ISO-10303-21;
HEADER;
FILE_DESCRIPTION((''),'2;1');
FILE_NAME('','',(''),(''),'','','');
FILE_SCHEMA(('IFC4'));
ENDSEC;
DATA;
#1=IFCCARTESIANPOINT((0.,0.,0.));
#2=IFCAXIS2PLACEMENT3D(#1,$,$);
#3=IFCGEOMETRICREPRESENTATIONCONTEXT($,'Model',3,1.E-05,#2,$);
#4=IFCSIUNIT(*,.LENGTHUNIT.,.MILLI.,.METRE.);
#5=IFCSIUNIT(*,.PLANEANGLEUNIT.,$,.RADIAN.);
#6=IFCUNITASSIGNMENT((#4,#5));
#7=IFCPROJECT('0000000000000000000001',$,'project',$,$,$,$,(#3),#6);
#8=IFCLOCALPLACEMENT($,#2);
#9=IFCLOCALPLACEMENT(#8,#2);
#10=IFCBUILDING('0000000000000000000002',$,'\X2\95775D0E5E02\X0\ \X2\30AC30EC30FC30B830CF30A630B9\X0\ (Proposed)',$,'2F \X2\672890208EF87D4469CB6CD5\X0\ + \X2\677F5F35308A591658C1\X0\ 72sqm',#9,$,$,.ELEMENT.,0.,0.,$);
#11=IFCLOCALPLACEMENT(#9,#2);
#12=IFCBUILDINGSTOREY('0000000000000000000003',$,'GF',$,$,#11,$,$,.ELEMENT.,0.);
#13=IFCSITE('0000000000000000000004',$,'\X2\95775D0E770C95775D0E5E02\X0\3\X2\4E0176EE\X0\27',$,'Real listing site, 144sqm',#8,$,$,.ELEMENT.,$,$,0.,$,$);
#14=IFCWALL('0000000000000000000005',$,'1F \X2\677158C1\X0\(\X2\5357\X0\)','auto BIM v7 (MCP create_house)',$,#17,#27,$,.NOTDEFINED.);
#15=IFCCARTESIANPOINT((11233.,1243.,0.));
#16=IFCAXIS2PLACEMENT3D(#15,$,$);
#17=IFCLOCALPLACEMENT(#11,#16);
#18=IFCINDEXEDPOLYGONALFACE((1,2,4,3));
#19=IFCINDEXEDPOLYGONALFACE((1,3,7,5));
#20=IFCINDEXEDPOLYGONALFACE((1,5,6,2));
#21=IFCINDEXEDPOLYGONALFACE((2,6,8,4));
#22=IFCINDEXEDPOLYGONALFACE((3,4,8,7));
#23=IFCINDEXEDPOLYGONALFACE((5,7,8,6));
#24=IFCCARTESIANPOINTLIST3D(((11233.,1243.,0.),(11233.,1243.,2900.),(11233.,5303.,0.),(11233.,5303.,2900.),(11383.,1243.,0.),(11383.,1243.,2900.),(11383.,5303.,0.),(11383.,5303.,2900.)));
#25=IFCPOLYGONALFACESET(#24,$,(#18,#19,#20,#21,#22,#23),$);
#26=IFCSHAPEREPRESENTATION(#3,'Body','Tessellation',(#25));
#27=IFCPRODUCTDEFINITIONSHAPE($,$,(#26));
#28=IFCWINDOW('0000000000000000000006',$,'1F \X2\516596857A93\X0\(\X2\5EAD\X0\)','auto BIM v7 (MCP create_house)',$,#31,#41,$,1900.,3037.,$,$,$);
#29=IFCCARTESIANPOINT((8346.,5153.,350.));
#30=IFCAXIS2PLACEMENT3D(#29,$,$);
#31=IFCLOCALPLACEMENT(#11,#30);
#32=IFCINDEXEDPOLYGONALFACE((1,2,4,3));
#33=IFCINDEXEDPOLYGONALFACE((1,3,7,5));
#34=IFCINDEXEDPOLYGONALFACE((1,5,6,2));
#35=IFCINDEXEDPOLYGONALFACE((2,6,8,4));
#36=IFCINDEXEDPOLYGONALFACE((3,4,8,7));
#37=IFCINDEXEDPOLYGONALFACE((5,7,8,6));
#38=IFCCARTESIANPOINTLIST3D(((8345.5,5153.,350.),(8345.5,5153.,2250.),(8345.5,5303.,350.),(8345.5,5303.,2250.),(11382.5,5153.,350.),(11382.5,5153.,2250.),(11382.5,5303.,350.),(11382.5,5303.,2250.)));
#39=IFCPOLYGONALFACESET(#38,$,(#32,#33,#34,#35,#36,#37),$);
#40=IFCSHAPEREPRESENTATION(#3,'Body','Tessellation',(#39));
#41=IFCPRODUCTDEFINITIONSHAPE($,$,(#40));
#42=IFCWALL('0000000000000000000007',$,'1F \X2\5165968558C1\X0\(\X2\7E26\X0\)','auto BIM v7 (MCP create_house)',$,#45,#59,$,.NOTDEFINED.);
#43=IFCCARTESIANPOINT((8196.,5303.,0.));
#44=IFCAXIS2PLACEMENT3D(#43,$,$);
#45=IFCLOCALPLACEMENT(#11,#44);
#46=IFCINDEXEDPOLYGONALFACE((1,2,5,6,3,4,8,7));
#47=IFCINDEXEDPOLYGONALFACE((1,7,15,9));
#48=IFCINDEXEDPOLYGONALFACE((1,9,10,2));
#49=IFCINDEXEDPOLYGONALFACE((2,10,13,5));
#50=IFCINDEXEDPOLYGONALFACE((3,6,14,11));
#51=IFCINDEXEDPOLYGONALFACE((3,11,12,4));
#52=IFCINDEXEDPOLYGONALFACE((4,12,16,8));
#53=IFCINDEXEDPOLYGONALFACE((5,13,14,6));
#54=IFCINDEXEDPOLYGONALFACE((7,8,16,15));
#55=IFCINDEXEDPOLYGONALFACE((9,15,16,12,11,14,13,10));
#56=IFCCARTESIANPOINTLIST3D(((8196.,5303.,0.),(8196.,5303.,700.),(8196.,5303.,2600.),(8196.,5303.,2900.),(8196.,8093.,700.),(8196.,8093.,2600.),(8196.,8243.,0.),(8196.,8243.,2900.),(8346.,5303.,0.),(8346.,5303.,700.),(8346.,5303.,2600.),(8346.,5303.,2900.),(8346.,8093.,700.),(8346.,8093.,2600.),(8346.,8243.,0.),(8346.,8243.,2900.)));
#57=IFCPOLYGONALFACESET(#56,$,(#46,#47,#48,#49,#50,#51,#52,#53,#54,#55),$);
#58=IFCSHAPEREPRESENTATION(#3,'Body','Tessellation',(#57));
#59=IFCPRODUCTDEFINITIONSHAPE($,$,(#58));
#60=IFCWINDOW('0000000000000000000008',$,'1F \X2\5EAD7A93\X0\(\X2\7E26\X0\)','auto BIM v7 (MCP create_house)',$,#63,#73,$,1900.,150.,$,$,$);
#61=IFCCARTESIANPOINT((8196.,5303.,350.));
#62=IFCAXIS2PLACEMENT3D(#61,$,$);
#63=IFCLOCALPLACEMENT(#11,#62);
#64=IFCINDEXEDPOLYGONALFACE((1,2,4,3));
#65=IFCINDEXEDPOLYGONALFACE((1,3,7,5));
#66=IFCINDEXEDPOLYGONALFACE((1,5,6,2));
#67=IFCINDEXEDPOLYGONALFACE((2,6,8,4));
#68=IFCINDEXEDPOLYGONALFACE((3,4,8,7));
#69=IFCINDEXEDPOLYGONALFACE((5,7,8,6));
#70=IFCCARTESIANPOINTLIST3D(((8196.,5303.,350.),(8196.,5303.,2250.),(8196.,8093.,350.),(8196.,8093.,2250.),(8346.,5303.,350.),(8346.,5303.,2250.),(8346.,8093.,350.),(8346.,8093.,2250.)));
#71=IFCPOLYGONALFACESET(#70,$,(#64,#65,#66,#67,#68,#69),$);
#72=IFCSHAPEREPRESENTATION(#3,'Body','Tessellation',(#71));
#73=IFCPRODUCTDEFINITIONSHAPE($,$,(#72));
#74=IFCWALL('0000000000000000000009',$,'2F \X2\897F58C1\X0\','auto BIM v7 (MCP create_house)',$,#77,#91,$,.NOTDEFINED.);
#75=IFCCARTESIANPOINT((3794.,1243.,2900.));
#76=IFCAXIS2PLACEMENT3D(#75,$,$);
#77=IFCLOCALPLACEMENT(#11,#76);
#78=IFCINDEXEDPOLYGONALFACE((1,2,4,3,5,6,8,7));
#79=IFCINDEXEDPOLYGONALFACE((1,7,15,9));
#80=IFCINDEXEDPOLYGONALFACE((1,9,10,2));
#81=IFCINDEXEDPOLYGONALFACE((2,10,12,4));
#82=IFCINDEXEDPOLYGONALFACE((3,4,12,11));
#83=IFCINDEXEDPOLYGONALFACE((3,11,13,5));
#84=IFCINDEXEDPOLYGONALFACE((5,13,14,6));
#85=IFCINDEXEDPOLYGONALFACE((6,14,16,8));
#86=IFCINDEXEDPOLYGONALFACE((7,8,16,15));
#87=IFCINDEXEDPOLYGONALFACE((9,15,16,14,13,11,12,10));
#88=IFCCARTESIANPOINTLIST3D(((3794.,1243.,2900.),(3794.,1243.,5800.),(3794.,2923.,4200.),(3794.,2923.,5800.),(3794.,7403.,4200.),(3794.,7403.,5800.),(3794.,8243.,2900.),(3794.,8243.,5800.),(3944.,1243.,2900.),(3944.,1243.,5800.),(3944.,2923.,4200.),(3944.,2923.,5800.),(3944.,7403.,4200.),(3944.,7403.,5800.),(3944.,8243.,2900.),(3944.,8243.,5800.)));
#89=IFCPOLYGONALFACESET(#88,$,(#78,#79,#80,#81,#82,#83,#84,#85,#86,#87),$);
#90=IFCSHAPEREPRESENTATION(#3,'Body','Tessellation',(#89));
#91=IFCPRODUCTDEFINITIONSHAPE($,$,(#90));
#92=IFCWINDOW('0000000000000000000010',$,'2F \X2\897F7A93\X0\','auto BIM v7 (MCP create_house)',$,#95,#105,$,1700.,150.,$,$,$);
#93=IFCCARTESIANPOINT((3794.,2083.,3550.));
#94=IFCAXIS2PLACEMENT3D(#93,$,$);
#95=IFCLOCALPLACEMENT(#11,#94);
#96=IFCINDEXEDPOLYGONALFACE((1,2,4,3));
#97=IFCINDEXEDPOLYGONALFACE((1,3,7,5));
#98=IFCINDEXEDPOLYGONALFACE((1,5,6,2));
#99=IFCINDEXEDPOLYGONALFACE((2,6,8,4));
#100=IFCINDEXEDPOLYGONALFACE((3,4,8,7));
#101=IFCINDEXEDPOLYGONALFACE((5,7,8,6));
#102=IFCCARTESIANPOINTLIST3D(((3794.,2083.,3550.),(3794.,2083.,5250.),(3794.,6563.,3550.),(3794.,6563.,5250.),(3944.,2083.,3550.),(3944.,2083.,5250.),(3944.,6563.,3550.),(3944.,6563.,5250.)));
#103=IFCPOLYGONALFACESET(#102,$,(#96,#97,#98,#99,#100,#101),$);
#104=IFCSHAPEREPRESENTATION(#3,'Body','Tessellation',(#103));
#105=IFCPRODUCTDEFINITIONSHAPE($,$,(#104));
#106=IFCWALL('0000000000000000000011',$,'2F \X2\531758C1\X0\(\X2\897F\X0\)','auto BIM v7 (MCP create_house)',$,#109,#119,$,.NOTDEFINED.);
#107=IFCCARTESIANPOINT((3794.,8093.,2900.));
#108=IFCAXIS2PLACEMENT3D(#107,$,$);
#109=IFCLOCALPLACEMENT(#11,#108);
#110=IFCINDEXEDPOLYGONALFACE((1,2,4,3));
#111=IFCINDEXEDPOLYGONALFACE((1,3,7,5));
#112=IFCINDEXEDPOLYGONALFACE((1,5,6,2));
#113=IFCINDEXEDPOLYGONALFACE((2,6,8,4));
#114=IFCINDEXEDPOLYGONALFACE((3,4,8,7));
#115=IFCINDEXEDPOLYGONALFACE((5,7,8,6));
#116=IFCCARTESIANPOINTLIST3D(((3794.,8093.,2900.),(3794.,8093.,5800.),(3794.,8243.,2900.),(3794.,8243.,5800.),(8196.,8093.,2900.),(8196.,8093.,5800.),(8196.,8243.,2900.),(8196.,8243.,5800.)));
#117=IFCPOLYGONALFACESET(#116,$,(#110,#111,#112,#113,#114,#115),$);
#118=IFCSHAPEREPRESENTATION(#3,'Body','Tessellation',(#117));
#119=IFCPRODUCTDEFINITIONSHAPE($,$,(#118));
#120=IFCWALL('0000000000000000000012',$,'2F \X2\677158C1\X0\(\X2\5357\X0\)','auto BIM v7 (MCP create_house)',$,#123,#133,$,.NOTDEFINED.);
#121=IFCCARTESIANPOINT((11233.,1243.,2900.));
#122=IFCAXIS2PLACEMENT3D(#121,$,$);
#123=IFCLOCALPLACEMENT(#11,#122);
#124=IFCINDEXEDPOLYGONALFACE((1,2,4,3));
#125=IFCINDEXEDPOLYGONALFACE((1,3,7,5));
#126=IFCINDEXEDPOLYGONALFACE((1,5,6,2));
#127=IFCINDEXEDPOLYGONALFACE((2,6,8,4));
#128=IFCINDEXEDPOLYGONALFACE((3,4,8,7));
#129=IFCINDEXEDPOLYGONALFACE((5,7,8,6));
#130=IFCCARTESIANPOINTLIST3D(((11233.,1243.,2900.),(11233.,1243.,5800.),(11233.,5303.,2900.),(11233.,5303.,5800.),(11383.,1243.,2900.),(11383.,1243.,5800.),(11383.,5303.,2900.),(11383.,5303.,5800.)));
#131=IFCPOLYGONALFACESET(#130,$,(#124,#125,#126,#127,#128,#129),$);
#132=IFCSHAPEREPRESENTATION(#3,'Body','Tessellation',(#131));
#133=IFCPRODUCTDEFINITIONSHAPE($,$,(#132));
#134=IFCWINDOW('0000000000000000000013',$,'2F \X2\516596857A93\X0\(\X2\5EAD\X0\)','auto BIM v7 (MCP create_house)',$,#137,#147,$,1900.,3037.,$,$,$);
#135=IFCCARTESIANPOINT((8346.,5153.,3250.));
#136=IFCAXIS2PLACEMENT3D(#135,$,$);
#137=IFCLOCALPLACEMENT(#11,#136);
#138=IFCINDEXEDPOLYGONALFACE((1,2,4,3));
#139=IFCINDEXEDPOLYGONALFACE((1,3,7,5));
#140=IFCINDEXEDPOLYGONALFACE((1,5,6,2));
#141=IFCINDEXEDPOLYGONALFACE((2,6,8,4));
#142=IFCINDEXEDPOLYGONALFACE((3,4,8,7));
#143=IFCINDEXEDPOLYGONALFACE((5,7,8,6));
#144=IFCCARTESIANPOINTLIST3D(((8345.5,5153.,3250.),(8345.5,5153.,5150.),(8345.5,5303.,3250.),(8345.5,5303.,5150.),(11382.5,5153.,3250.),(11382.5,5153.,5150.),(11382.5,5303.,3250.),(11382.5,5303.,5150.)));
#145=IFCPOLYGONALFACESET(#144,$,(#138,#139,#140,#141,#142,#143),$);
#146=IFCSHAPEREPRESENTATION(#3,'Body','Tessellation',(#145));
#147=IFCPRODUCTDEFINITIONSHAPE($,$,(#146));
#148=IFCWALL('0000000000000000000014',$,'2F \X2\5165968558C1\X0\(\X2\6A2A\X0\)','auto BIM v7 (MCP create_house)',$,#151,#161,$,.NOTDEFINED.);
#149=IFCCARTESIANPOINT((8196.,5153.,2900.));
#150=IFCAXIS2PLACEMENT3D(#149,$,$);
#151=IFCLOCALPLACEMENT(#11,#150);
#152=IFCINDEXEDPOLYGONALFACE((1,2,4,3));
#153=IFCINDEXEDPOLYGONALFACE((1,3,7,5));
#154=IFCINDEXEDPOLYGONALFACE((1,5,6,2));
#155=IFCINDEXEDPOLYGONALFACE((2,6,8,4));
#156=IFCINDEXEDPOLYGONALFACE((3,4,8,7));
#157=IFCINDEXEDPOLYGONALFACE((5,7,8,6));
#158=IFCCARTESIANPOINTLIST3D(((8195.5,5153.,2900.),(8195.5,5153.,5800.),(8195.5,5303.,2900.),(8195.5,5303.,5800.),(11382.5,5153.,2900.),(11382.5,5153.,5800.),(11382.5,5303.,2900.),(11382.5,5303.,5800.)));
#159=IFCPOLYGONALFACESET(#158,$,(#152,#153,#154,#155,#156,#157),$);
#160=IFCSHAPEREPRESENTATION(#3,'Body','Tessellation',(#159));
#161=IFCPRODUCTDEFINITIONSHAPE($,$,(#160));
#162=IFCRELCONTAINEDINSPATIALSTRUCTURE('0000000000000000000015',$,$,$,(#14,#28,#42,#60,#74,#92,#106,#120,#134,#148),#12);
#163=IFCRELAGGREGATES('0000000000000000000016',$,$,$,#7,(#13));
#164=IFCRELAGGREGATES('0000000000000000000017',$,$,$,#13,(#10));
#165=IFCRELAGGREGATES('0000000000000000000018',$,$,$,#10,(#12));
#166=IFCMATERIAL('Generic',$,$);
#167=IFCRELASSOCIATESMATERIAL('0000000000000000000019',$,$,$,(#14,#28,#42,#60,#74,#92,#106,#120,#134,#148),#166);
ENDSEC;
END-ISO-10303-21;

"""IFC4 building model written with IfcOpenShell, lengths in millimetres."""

from ifc_helpers import new_model, si_unit, frame, frame_2d, origin, place, context, project, spatial, rectangle, extrude, material, element, fill, save


model = new_model("IFC4")

# Units and contexts
model_context = context("Model", 3, precision=1e-05, world=origin())
ifc_project = project(units=[si_unit("LENGTHUNIT", "METRE", prefix="MILLI"), si_unit("PLANEANGLEUNIT", "RADIAN")], contexts=[model_context])

# Site, building, storey
site_placement = place(None, origin())
site = spatial("IfcSite", under=ifc_project, at=site_placement, Name="長崎県長崎市3丁目27", ObjectType="Real listing site, 144sqm", CompositionType="ELEMENT", RefElevation=0.0)
building_placement = place(site_placement, origin())
building = spatial("IfcBuilding", under=site, at=building_placement, Name="長崎市 ガレージハウス (Proposed)", ObjectType="2F 木造軸組構法 + 板張り外壁 72sqm", CompositionType="ELEMENT", ElevationOfRefHeight=0.0, ElevationOfTerrain=0.0)
storey_placement = place(building_placement, origin())
storey = spatial("IfcBuildingStorey", under=building, at=storey_placement, Name="GF", CompositionType="ELEMENT", Elevation=0.0)

# Shared definitions
ifc_material = material(Name="Generic")

# Wall, opening, window
wall_1_placement = place(storey_placement, frame((11233.0, 1243.0, 0.0)))
wall_1 = element("IfcWall", 1, at=wall_1_placement, inside=storey, material=ifc_material, Name="1F 東壁(南)", Description="auto BIM v7 (MCP create_house)", PredefinedType="NOTDEFINED", context=model_context, shape_type="SweptSolid", body=[
    extrude(rectangle(XDim=150.0, YDim=4060.0, at=frame_2d((75.0, 2030.0))), frame((11233.0, 1243.0, 0.0)), (0.0, 0.0, 1.0), 2900.0),
])
opening_1_placement = place(storey_placement, frame((8346.0, 5153.0, 350.0)))
opening_1 = element("IfcOpeningElement", 2, at=opening_1_placement, cuts=wall_1, PredefinedType="NOTDEFINED", context=model_context, shape_type="SweptSolid", body=[
    extrude(rectangle(XDim=3037.0, YDim=150.0, at=frame_2d((1518.0, 75.0))), frame((8346.0, 5153.0, 350.0)), (0.0, 0.0, 1.0), 1900.0),
])
window_1_placement = place(storey_placement, frame((8346.0, 5153.0, 350.0)))
window_1 = element("IfcWindow", 3, at=window_1_placement, inside=storey, material=ifc_material, Name="1F 入隅窓(庭)", Description="auto BIM v7 (MCP create_house)", OverallHeight=1900.0, OverallWidth=3037.0, context=model_context, shape_type="SweptSolid", body=[
    extrude(rectangle(XDim=3037.0, YDim=150.0, at=frame_2d((1518.0, 75.0))), frame((8346.0, 5153.0, 350.0)), (0.0, 0.0, 1.0), 1900.0),
])
fill(opening_1, window_1)

# Wall, opening, window
wall_2_placement = place(storey_placement, frame((8196.0, 5303.0, 0.0)))
wall_2 = element("IfcWall", 4, at=wall_2_placement, inside=storey, material=ifc_material, Name="1F 入隅壁(縦)", Description="auto BIM v7 (MCP create_house)", PredefinedType="NOTDEFINED", context=model_context, shape_type="SweptSolid", body=[
    extrude(rectangle(XDim=150.0, YDim=2940.0, at=frame_2d((75.0, 1470.0))), frame((8196.0, 5303.0, 0.0)), (0.0, 0.0, 1.0), 2900.0),
])
opening_2_placement = place(storey_placement, frame((8196.0, 5303.0, 350.0)))
opening_2 = element("IfcOpeningElement", 5, at=opening_2_placement, cuts=wall_2, PredefinedType="NOTDEFINED", context=model_context, shape_type="SweptSolid", body=[
    extrude(rectangle(XDim=150.0, YDim=2790.0, at=frame_2d((75.0, 1395.0))), frame((8196.0, 5303.0, 350.0)), (0.0, 0.0, 1.0), 1900.0),
])
window_2_placement = place(storey_placement, frame((8196.0, 5303.0, 350.0)))
window_2 = element("IfcWindow", 6, at=window_2_placement, inside=storey, material=ifc_material, Name="1F 庭窓(縦)", Description="auto BIM v7 (MCP create_house)", OverallHeight=1900.0, OverallWidth=150.0, context=model_context, shape_type="SweptSolid", body=[
    extrude(rectangle(XDim=150.0, YDim=2790.0, at=frame_2d((75.0, 1395.0))), frame((8196.0, 5303.0, 350.0)), (0.0, 0.0, 1.0), 1900.0),
])
fill(opening_2, window_2)

# Wall, opening, window
wall_3_placement = place(storey_placement, frame((3794.0, 1243.0, 2900.0)))
wall_3 = element("IfcWall", 7, at=wall_3_placement, inside=storey, material=ifc_material, Name="2F 西壁", Description="auto BIM v7 (MCP create_house)", PredefinedType="NOTDEFINED", context=model_context, shape_type="SweptSolid", body=[
    extrude(rectangle(XDim=150.0, YDim=7000.0, at=frame_2d((75.0, 3500.0))), frame((3794.0, 1243.0, 2900.0)), (0.0, 0.0, 1.0), 2900.0),
])
opening_3_placement = place(storey_placement, frame((3794.0, 2083.0, 3550.0)))
opening_3 = element("IfcOpeningElement", 8, at=opening_3_placement, cuts=wall_3, PredefinedType="NOTDEFINED", context=model_context, shape_type="SweptSolid", body=[
    extrude(rectangle(XDim=150.0, YDim=4480.0, at=frame_2d((75.0, 2240.0))), frame((3794.0, 2083.0, 3550.0)), (0.0, 0.0, 1.0), 1700.0),
])
window_3_placement = place(storey_placement, frame((3794.0, 2083.0, 3550.0)))
window_3 = element("IfcWindow", 9, at=window_3_placement, inside=storey, material=ifc_material, Name="2F 西窓", Description="auto BIM v7 (MCP create_house)", OverallHeight=1700.0, OverallWidth=150.0, context=model_context, shape_type="SweptSolid", body=[
    extrude(rectangle(XDim=150.0, YDim=4480.0, at=frame_2d((75.0, 2240.0))), frame((3794.0, 2083.0, 3550.0)), (0.0, 0.0, 1.0), 1700.0),
])
fill(opening_3, window_3)

# Wall
wall_4_placement = place(storey_placement, frame((3794.0, 8093.0, 2900.0)))
element("IfcWall", 10, at=wall_4_placement, inside=storey, material=ifc_material, Name="2F 北壁(西)", Description="auto BIM v7 (MCP create_house)", PredefinedType="NOTDEFINED", context=model_context, shape_type="SweptSolid", body=[
    extrude(rectangle(XDim=4402.0, YDim=150.0, at=frame_2d((2201.0, 75.0))), frame((3794.0, 8093.0, 2900.0)), (0.0, 0.0, 1.0), 2900.0),
])

# Wall, opening, window
wall_5_placement = place(storey_placement, frame((11233.0, 1243.0, 2900.0)))
wall_5 = element("IfcWall", 11, at=wall_5_placement, inside=storey, material=ifc_material, Name="2F 東壁(南)", Description="auto BIM v7 (MCP create_house)", PredefinedType="NOTDEFINED", context=model_context, shape_type="SweptSolid", body=[
    extrude(rectangle(XDim=150.0, YDim=4060.0, at=frame_2d((75.0, 2030.0))), frame((11233.0, 1243.0, 2900.0)), (0.0, 0.0, 1.0), 2900.0),
])
opening_4_placement = place(storey_placement, frame((8346.0, 5153.0, 3250.0)))
opening_4 = element("IfcOpeningElement", 12, at=opening_4_placement, cuts=wall_5, PredefinedType="NOTDEFINED", context=model_context, shape_type="SweptSolid", body=[
    extrude(rectangle(XDim=3037.0, YDim=150.0, at=frame_2d((1518.0, 75.0))), frame((8346.0, 5153.0, 3250.0)), (0.0, 0.0, 1.0), 1900.0),
])
window_4_placement = place(storey_placement, frame((8346.0, 5153.0, 3250.0)))
window_4 = element("IfcWindow", 13, at=window_4_placement, inside=storey, material=ifc_material, Name="2F 入隅窓(庭)", Description="auto BIM v7 (MCP create_house)", OverallHeight=1900.0, OverallWidth=3037.0, context=model_context, shape_type="SweptSolid", body=[
    extrude(rectangle(XDim=3037.0, YDim=150.0, at=frame_2d((1518.0, 75.0))), frame((8346.0, 5153.0, 3250.0)), (0.0, 0.0, 1.0), 1900.0),
])
fill(opening_4, window_4)

# Wall
wall_6_placement = place(storey_placement, frame((8196.0, 5153.0, 2900.0)))
element("IfcWall", 14, at=wall_6_placement, inside=storey, material=ifc_material, Name="2F 入隅壁(横)", Description="auto BIM v7 (MCP create_house)", PredefinedType="NOTDEFINED", context=model_context, shape_type="SweptSolid", body=[
    extrude(rectangle(XDim=3187.0, YDim=150.0, at=frame_2d((1593.0, 75.0))), frame((8196.0, 5153.0, 2900.0)), (0.0, 0.0, 1.0), 2900.0),
])

save(model, "model.ifc")
